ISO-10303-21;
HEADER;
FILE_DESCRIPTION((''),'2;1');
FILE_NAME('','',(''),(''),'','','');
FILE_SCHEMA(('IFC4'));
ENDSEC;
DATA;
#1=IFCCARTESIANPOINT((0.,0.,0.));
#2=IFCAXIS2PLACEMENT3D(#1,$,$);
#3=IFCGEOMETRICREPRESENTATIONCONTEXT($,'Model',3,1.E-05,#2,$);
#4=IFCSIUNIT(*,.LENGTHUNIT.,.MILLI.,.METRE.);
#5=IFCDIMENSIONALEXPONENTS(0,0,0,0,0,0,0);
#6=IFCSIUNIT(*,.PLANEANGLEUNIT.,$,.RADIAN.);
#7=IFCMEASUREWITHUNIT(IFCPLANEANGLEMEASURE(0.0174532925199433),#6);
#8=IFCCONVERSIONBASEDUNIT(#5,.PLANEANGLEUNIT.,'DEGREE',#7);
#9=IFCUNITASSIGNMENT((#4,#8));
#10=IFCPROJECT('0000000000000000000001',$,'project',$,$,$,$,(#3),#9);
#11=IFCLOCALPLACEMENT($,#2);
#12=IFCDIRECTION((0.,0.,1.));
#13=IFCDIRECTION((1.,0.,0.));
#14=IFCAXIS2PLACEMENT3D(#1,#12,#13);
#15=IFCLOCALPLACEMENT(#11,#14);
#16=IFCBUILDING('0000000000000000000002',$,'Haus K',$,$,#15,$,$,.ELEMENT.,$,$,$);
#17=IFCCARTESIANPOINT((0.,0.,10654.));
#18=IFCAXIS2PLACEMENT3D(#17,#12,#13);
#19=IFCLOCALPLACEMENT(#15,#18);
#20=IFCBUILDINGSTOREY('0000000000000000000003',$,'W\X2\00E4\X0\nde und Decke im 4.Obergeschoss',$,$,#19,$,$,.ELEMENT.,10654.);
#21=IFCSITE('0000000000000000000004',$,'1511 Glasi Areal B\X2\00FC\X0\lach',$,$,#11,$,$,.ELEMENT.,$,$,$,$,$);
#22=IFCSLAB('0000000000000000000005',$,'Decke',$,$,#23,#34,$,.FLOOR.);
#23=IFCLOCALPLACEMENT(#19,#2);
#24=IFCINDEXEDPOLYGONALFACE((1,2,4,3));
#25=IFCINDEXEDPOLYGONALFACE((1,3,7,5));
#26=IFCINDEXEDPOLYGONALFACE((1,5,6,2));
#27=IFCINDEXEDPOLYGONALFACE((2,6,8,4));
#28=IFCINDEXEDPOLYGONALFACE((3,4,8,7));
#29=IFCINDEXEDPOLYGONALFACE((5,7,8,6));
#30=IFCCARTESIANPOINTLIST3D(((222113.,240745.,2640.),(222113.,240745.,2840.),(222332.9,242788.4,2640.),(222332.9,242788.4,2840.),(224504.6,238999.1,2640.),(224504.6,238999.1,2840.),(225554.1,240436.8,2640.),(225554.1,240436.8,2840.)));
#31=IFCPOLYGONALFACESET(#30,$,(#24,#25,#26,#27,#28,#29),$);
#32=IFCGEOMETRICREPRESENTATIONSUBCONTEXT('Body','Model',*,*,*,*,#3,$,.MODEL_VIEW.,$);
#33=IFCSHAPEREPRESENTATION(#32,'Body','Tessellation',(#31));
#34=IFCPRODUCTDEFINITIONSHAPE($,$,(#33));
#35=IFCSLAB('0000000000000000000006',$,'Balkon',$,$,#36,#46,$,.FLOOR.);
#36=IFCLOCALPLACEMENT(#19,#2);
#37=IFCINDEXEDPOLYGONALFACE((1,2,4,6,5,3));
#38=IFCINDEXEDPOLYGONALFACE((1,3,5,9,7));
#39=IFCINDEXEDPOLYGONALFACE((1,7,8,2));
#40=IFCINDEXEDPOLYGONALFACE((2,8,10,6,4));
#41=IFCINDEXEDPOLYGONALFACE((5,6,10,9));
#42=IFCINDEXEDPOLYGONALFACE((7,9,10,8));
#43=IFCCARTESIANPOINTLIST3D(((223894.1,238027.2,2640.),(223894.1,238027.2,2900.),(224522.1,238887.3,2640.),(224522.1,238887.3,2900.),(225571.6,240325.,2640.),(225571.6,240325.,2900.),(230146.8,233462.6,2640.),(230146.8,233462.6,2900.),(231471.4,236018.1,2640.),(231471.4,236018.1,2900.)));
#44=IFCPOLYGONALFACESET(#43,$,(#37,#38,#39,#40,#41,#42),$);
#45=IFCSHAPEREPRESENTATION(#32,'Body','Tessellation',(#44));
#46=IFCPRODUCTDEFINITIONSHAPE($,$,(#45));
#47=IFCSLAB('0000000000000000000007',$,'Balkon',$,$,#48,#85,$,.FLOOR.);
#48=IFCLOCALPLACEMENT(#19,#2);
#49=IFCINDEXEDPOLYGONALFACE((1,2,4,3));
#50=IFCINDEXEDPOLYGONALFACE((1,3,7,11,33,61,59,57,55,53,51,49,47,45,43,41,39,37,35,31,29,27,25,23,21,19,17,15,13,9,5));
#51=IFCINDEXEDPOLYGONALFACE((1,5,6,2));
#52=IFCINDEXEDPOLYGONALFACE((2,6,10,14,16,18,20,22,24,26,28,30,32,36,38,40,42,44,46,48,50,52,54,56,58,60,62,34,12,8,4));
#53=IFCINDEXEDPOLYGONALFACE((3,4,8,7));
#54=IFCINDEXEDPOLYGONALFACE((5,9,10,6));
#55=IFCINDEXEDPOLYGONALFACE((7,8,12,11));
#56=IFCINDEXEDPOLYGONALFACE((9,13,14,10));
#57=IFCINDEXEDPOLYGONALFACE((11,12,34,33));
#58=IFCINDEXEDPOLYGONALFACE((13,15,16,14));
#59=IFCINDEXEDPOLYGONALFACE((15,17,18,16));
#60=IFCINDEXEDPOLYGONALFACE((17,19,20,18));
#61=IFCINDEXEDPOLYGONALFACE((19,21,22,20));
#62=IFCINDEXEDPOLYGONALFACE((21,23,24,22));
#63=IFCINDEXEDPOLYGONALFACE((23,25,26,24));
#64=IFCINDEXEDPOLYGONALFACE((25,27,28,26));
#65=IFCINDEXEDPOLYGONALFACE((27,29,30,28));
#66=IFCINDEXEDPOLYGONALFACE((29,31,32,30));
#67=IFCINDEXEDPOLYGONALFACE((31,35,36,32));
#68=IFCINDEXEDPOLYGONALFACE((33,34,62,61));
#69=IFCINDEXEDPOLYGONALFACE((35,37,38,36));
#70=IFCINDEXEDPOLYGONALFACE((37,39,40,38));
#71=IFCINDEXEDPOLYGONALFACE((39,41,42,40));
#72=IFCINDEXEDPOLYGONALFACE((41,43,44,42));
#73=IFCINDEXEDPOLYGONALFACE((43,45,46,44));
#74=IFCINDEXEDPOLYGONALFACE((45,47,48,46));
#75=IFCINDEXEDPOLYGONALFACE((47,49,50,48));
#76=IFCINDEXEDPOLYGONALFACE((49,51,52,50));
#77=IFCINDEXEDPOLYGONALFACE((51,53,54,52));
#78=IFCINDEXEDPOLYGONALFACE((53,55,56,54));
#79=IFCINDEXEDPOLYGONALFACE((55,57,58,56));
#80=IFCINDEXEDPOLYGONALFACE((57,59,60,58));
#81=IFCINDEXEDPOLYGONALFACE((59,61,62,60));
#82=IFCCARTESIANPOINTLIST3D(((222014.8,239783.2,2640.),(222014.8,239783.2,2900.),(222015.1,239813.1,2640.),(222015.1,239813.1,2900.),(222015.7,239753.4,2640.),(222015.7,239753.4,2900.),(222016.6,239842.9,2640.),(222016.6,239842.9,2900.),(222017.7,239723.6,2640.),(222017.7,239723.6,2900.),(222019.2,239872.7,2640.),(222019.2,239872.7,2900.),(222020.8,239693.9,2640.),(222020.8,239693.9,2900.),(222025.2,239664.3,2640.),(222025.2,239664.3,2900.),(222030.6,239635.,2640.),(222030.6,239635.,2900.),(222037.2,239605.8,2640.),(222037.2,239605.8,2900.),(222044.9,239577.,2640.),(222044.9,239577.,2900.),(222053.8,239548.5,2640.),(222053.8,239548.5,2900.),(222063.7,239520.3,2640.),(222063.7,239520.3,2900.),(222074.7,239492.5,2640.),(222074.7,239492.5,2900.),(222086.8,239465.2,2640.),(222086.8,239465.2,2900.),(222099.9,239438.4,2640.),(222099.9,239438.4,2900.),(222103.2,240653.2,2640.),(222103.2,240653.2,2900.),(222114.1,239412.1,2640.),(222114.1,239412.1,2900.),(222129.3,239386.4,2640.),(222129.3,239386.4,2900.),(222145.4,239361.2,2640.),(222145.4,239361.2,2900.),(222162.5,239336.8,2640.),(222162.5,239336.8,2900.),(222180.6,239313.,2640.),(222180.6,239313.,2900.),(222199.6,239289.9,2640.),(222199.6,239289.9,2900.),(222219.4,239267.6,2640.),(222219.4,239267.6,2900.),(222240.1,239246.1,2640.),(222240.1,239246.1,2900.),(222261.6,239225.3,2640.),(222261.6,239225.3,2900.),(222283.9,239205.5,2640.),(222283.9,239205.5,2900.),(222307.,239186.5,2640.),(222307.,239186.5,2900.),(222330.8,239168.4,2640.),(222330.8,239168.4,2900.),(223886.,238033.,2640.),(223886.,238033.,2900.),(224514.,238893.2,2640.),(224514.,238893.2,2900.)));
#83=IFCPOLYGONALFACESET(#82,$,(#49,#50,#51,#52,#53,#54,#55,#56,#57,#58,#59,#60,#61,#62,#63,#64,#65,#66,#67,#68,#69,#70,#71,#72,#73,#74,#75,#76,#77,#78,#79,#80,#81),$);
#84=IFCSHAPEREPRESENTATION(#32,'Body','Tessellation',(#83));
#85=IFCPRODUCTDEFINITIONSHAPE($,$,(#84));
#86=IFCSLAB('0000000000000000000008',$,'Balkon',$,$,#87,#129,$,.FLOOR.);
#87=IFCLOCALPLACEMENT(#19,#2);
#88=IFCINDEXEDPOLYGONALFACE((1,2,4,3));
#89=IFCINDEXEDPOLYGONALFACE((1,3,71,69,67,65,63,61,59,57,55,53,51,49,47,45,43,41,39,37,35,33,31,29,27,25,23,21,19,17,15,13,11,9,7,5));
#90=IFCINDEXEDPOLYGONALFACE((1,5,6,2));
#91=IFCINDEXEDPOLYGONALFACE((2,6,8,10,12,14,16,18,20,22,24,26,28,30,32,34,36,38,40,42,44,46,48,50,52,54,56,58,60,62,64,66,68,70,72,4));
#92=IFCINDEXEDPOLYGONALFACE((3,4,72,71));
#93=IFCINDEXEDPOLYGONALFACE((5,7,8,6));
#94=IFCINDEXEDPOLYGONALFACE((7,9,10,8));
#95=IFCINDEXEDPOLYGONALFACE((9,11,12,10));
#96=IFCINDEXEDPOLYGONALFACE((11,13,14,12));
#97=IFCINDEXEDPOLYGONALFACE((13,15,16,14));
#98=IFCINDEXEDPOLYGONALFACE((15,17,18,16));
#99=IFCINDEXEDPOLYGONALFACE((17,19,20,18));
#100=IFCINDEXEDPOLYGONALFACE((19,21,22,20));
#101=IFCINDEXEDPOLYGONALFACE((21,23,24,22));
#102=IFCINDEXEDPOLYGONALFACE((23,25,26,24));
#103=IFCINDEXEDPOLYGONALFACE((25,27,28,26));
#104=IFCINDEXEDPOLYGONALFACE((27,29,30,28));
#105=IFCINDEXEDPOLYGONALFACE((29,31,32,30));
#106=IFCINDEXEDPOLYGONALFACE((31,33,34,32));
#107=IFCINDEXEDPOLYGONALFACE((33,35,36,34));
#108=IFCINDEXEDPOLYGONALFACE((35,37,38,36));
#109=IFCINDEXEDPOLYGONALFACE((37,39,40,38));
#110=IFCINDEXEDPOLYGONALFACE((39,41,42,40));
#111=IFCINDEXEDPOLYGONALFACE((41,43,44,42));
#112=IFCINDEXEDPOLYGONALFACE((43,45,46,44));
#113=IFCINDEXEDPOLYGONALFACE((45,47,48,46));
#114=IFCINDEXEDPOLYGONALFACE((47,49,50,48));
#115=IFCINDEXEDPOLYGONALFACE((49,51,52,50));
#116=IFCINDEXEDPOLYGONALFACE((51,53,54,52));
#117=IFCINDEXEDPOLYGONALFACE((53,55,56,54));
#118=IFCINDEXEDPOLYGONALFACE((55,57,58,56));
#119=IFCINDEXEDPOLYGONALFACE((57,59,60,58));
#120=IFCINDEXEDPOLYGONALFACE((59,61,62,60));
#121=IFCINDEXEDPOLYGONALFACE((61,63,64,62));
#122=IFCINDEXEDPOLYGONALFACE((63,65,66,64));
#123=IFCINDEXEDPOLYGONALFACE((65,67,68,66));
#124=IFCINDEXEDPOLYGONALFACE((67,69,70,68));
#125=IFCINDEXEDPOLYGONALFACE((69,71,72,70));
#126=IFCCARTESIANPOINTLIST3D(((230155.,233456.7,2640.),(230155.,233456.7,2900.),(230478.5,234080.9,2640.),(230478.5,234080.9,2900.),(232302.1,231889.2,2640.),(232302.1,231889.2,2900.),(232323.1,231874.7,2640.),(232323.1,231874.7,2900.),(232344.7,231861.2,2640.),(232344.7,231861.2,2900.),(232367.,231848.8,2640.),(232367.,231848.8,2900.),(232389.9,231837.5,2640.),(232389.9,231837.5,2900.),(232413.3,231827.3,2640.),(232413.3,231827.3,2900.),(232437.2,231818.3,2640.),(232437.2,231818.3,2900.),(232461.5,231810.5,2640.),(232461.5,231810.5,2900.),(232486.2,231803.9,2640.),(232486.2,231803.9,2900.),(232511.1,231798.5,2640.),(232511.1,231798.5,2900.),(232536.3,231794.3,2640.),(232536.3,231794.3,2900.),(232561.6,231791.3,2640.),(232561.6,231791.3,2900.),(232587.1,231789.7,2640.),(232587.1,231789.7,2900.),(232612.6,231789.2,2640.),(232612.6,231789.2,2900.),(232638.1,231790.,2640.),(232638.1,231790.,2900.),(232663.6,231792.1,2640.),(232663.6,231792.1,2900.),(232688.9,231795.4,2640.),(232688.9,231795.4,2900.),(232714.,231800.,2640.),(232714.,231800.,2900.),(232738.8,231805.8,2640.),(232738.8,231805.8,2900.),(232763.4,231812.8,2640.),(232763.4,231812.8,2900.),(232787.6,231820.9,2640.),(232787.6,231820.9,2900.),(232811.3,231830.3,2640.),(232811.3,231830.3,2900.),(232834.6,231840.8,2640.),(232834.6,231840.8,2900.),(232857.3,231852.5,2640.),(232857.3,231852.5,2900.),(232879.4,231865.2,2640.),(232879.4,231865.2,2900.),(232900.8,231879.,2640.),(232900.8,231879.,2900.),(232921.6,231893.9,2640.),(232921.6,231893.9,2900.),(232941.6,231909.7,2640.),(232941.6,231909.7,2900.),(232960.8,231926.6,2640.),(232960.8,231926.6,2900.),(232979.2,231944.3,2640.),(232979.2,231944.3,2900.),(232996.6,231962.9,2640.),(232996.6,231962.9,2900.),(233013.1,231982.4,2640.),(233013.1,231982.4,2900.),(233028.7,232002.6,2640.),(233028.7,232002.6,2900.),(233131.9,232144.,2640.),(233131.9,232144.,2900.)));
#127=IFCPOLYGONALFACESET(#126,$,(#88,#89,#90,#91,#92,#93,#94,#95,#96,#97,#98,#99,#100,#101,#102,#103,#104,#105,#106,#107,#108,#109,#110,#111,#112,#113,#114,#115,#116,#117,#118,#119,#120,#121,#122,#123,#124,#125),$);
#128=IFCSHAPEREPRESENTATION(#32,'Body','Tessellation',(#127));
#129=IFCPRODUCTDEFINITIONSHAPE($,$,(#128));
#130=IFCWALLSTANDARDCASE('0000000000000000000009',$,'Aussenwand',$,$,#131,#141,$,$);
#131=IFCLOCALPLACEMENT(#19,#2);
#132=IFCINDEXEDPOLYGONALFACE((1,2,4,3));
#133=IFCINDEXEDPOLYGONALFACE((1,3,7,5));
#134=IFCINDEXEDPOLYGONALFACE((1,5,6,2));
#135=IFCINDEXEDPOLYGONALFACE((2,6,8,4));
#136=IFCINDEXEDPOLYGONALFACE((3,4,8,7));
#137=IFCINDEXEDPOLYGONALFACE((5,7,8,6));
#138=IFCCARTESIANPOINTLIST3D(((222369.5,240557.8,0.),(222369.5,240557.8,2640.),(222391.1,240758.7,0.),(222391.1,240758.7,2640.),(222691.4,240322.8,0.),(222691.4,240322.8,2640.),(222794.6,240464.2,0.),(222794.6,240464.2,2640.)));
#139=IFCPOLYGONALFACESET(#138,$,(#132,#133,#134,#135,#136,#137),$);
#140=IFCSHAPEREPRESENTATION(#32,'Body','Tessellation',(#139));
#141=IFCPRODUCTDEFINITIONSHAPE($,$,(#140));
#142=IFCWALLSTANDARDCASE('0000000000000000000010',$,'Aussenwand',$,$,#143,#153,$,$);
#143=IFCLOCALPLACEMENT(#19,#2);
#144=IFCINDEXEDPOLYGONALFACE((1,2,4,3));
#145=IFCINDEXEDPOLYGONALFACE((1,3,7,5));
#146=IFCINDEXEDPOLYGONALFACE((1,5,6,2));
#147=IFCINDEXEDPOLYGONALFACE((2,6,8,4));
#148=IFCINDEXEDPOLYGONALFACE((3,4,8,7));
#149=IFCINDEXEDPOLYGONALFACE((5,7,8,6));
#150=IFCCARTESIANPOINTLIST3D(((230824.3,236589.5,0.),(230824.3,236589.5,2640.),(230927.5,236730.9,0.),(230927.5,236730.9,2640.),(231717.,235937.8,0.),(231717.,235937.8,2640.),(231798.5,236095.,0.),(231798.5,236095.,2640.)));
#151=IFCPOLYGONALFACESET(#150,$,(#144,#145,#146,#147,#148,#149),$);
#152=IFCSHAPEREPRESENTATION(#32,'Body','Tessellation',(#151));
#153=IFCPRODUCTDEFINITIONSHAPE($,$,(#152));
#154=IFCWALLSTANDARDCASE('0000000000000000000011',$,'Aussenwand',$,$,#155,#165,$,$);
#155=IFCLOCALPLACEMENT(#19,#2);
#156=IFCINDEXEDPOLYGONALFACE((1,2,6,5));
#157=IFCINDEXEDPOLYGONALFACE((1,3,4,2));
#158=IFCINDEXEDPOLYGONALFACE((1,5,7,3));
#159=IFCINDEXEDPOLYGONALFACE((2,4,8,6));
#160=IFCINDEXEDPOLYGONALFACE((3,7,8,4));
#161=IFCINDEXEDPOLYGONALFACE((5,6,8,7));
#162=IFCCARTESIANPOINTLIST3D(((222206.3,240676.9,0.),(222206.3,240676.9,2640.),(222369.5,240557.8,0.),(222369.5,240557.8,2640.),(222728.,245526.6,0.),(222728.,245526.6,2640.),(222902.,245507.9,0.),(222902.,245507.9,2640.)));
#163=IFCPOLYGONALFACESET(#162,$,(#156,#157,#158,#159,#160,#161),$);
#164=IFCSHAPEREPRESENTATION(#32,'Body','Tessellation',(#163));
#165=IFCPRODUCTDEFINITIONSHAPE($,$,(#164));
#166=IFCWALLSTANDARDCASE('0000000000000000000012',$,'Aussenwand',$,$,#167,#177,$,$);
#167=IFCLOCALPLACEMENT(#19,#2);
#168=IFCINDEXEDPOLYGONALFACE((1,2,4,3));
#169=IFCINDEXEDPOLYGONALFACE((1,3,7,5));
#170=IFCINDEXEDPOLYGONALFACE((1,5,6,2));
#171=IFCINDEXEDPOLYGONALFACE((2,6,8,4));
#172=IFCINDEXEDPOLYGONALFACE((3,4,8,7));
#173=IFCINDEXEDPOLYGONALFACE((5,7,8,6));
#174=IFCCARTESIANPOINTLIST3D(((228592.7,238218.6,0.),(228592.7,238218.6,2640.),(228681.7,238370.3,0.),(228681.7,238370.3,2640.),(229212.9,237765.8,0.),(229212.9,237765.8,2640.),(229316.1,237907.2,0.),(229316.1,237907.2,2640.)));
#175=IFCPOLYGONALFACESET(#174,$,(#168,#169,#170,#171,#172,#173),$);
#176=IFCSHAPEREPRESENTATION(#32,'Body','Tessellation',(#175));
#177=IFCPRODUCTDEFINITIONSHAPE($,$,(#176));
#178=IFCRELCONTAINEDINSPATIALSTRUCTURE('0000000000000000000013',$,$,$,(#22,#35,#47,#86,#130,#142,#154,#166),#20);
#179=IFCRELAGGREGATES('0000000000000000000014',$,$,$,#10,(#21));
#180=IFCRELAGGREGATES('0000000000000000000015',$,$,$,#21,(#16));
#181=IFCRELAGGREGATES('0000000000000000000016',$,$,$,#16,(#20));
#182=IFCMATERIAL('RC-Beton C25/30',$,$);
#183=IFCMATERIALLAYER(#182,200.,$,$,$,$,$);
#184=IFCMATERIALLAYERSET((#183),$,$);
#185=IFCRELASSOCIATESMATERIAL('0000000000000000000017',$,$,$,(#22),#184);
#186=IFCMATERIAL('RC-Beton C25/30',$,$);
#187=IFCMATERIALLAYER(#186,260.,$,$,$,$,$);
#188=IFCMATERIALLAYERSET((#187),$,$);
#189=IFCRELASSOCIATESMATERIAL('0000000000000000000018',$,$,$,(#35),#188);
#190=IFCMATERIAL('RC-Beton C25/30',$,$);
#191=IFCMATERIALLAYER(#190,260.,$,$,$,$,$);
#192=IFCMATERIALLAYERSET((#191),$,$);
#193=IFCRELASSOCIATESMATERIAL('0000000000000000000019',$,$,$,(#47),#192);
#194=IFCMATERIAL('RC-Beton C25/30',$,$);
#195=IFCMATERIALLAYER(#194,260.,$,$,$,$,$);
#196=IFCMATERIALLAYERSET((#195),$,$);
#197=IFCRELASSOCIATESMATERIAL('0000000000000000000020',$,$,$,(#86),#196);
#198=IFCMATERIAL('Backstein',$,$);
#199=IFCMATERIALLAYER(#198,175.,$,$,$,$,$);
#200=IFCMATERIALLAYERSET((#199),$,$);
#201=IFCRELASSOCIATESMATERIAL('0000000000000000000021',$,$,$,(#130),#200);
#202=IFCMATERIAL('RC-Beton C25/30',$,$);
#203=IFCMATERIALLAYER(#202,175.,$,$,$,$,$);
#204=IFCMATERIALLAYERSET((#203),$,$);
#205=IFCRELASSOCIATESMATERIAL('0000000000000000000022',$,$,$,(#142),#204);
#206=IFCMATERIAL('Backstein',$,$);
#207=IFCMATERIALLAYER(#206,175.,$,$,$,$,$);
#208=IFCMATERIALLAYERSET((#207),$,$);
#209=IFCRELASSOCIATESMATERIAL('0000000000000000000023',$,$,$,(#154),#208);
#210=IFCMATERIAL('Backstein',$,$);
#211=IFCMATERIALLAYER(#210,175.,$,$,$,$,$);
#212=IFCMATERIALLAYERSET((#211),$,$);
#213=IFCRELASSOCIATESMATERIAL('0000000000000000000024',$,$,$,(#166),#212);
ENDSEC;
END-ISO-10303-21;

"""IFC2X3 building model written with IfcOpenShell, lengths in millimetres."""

from ifc_helpers import new_model, entity, si_unit, converted_unit, frame, origin, origin_with_axes, place, context, subcontext, project, spatial, polyline, outline, extrude, material, layer, layer_set, layer_usage, element, save


model = new_model("IFC2X3")

# Units and contexts
model_context = context("Model", 3, precision=1e-05, world=origin())
body_context = subcontext(model_context, "Body", "Model", "MODEL_VIEW")
ifc_project = project(units=[si_unit("LENGTHUNIT", "METRE", prefix="MILLI"), converted_unit("PLANEANGLEUNIT", "DEGREE", entity("IfcPlaneAngleMeasure", 0.0174532925199433), si_unit("PLANEANGLEUNIT", "RADIAN"), dimensions=[0, 0, 0, 0, 0, 0, 0])], contexts=[model_context])

# Site, building, storey
site_placement = place(None, origin())
site = spatial("IfcSite", under=ifc_project, at=site_placement, Name="1511 Glasi Areal Bülach", CompositionType="ELEMENT")
building_placement = place(site_placement, origin_with_axes())
building = spatial("IfcBuilding", under=site, at=building_placement, Name="Haus K", CompositionType="ELEMENT")
storey_placement = place(building_placement, frame((0.0, 0.0, 10654.0), z_axis=(0.0, 0.0, 1.0), x_axis=(1.0, 0.0, 0.0)))
storey = spatial("IfcBuildingStorey", under=building, at=storey_placement, Name="Wände und Decke im 4.Obergeschoss", CompositionType="ELEMENT", Elevation=10654.0)

# Slabs
ifc_material_1 = material(Name="RC-Beton C25/30")
ifc_layer_1 = layer(ifc_material_1, 200.0)
ifc_layer_set_1 = layer_set([ifc_layer_1])
ifc_layer_usage_1 = layer_usage(ifc_layer_set_1, "AXIS3", "POSITIVE", 0.0)
slab_1_placement = place(storey_placement, frame((222113.0, 238999.1, 2640.0), z_axis=(0.0, 0.0, 1.0), x_axis=(1.0, 0.0, 0.0)))
element("IfcSlab", 1, at=slab_1_placement, inside=storey, material=ifc_layer_usage_1, Name="Decke", PredefinedType="FLOOR", context=body_context, shape_type="SweptSolid", body=[
    extrude(outline(polyline([(219.8, 3789.3), (0.0, 1745.9), (2391.6, 0.0), (3441.1, 1437.7), (219.8, 3789.3)])), origin_with_axes(), (0.0, 0.0, 1.0), 200.0),
])
ifc_material_2 = material(Name="RC-Beton C25/30")
ifc_layer_2 = layer(ifc_material_2, 260.0)
ifc_layer_set_2 = layer_set([ifc_layer_2])
ifc_layer_usage_2 = layer_usage(ifc_layer_set_2, "AXIS3", "POSITIVE", 0.0)
slab_2_placement = place(storey_placement, frame((223894.1, 233462.6, 2640.0), z_axis=(0.0, 0.0, 1.0), x_axis=(1.0, 0.0, 0.0)))
element("IfcSlab", 2, at=slab_2_placement, inside=storey, material=ifc_layer_usage_2, Name="Balkon", PredefinedType="FLOOR", context=body_context, shape_type="SweptSolid", body=[
    extrude(outline(polyline([(0.0, 4564.5), (6252.7, 0.0), (7577.3, 2555.4), (1677.5, 6862.4), (627.9, 5424.7), (0.0, 4564.5)])), origin_with_axes(), (0.0, 0.0, 1.0), 260.0),
])
ifc_material_3 = material(Name="RC-Beton C25/30")
ifc_layer_3 = layer(ifc_material_3, 260.0)
ifc_layer_set_3 = layer_set([ifc_layer_3])
ifc_layer_usage_3 = layer_usage(ifc_layer_set_3, "AXIS3", "POSITIVE", 0.0)
slab_3_placement = place(storey_placement, frame((222014.8, 238033.0, 2640.0), z_axis=(0.0, 0.0, 1.0), x_axis=(1.0, 0.0, 0.0)))
element("IfcSlab", 3, at=slab_3_placement, inside=storey, material=ifc_layer_usage_3, Name="Balkon", PredefinedType="FLOOR", context=body_context, shape_type="SweptSolid", body=[
    extrude(outline(polyline([(1.8, 1809.9), (0.3, 1780.1), (0.0, 1750.2), (0.9, 1720.3), (2.9, 1690.5), (6.0, 1660.8), (10.3, 1631.3), (15.8, 1601.9), (22.4, 1572.8), (30.1, 1543.9), (38.9, 1515.4), (48.9, 1487.2), (59.9, 1459.5), (72.0, 1432.2), (85.1, 1405.3), (99.3, 1379.0), (114.4, 1353.3), (130.6, 1328.2), (147.7, 1303.7), (165.8, 1279.9), (184.8, 1256.9), (204.6, 1234.5), (225.3, 1213.0), (246.8, 1192.3), (269.1, 1172.4), (292.2, 1153.4), (316.0, 1135.4), (1871.2, 0.0), (2499.2, 860.2), (88.3, 2620.1), (4.4, 1839.6), (1.8, 1809.9)])), origin_with_axes(), (0.0, 0.0, 1.0), 260.0),
])
ifc_material_4 = material(Name="RC-Beton C25/30")
ifc_layer_4 = layer(ifc_material_4, 260.0)
ifc_layer_set_4 = layer_set([ifc_layer_4])
ifc_layer_usage_4 = layer_usage(ifc_layer_set_4, "AXIS3", "POSITIVE", 0.0)
slab_4_placement = place(storey_placement, frame((230155.0, 231789.2, 2640.0), z_axis=(0.0, 0.0, 1.0), x_axis=(1.0, 0.0, 0.0)))
element("IfcSlab", 4, at=slab_4_placement, inside=storey, material=ifc_layer_usage_4, Name="Balkon", PredefinedType="FLOOR", context=body_context, shape_type="SweptSolid", body=[
    extrude(outline(polyline([(2147.1, 100.0), (2168.1, 85.5), (2189.8, 72.0), (2212.1, 59.5), (2235.0, 48.2), (2258.4, 38.1), (2282.2, 29.1), (2306.5, 21.3), (2331.2, 14.6), (2356.1, 9.2), (2381.3, 5.1), (2406.7, 2.1), (2432.1, 0.4), (2457.7, 0.0), (2483.2, 0.8), (2508.6, 2.9), (2533.9, 6.2), (2559.0, 10.8), (2583.9, 16.5), (2608.4, 23.5), (2632.6, 31.7), (2656.3, 41.1), (2679.6, 51.6), (2702.3, 63.2), (2724.4, 76.0), (2745.9, 89.8), (2766.6, 104.7), (2786.6, 120.5), (2805.8, 137.3), (2824.2, 155.1), (2841.7, 173.7), (2858.2, 193.1), (2873.7, 213.4), (2976.9, 354.7), (323.6, 2291.7), (0.0, 1667.4), (2147.1, 100.0)])), origin_with_axes(), (0.0, 0.0, 1.0), 260.0),
])

# Walls
ifc_material_5 = material(Name="Backstein")
ifc_layer_5 = layer(ifc_material_5, 175.0)
ifc_layer_set_5 = layer_set([ifc_layer_5])
ifc_layer_usage_5 = layer_usage(ifc_layer_set_5, "AXIS2", "POSITIVE", 0.0)
wall_1_placement = place(storey_placement, frame((222369.5, 240557.8, 0.0), z_axis=(0.0, 0.0, 1.0), x_axis=(0.807681, -0.589619, 0.0)))
element("IfcWallStandardCase", 5, at=wall_1_placement, inside=storey, material=ifc_layer_usage_5, Name="Aussenwand", context=body_context, shape_type="SweptSolid", body=[
    extrude(outline(polyline([(0.0, 0.0), (398.5, 0.0), (398.5, 175.0), (-101.0, 175.0), (0.0, 0.0)])), origin_with_axes(), (0.0, 0.0, 1.0), 2640.0),
])
ifc_material_6 = material(Name="RC-Beton C25/30")
ifc_layer_6 = layer(ifc_material_6, 175.0)
ifc_layer_set_6 = layer_set([ifc_layer_6])
ifc_layer_usage_6 = layer_usage(ifc_layer_set_6, "AXIS2", "POSITIVE", 0.0)
wall_2_placement = place(storey_placement, frame((230824.3, 236589.5, 0.0), z_axis=(0.0, 0.0, 1.0), x_axis=(0.807681, -0.589619, 0.0)))
element("IfcWallStandardCase", 6, at=wall_2_placement, inside=storey, material=ifc_layer_usage_6, Name="Aussenwand", context=body_context, shape_type="SweptSolid", body=[
    extrude(outline(polyline([(0.0, 0.0), (1105.3, 0.0), (1078.5, 175.0), (0.0, 175.0), (0.0, 0.0)])), origin_with_axes(), (0.0, 0.0, 1.0), 2640.0),
])
ifc_material_7 = material(Name="Backstein")
ifc_layer_7 = layer(ifc_material_7, 175.0)
ifc_layer_set_7 = layer_set([ifc_layer_7])
ifc_layer_usage_7 = layer_usage(ifc_layer_set_7, "AXIS2", "POSITIVE", 0.0)
wall_3_placement = place(storey_placement, frame((222728.0, 245526.6, 0.0), z_axis=(0.0, 0.0, 1.0), x_axis=(-0.106958, -0.994264, 0.0)))
element("IfcWallStandardCase", 7, at=wall_3_placement, inside=storey, material=ifc_layer_usage_7, Name="Aussenwand", context=body_context, shape_type="SweptSolid", body=[
    extrude(outline(polyline([(0.0, 0.0), (4877.7, 0.0), (4978.7, 175.0), (0.0, 175.0), (0.0, 0.0)])), origin_with_axes(), (0.0, 0.0, 1.0), 2640.0),
])
ifc_material_8 = material(Name="Backstein")
ifc_layer_8 = layer(ifc_material_8, 175.0)
ifc_layer_set_8 = layer_set([ifc_layer_8])
ifc_layer_usage_8 = layer_usage(ifc_layer_set_8, "AXIS2", "POSITIVE", 0.0)
wall_4_placement = place(storey_placement, frame((228592.7, 238218.6, 0.0), z_axis=(0.0, 0.0, 1.0), x_axis=(0.807681, -0.589619, 0.0)))
element("IfcWallStandardCase", 8, at=wall_4_placement, inside=storey, material=ifc_layer_usage_8, Name="Aussenwand", context=body_context, shape_type="SweptSolid", body=[
    extrude(outline(polyline([(0.0, 0.0), (767.9, 0.0), (767.9, 175.0), (-17.6, 175.0), (0.0, 0.0)])), origin_with_axes(), (0.0, 0.0, 1.0), 2640.0),
])

save(model, "model.ifc")
